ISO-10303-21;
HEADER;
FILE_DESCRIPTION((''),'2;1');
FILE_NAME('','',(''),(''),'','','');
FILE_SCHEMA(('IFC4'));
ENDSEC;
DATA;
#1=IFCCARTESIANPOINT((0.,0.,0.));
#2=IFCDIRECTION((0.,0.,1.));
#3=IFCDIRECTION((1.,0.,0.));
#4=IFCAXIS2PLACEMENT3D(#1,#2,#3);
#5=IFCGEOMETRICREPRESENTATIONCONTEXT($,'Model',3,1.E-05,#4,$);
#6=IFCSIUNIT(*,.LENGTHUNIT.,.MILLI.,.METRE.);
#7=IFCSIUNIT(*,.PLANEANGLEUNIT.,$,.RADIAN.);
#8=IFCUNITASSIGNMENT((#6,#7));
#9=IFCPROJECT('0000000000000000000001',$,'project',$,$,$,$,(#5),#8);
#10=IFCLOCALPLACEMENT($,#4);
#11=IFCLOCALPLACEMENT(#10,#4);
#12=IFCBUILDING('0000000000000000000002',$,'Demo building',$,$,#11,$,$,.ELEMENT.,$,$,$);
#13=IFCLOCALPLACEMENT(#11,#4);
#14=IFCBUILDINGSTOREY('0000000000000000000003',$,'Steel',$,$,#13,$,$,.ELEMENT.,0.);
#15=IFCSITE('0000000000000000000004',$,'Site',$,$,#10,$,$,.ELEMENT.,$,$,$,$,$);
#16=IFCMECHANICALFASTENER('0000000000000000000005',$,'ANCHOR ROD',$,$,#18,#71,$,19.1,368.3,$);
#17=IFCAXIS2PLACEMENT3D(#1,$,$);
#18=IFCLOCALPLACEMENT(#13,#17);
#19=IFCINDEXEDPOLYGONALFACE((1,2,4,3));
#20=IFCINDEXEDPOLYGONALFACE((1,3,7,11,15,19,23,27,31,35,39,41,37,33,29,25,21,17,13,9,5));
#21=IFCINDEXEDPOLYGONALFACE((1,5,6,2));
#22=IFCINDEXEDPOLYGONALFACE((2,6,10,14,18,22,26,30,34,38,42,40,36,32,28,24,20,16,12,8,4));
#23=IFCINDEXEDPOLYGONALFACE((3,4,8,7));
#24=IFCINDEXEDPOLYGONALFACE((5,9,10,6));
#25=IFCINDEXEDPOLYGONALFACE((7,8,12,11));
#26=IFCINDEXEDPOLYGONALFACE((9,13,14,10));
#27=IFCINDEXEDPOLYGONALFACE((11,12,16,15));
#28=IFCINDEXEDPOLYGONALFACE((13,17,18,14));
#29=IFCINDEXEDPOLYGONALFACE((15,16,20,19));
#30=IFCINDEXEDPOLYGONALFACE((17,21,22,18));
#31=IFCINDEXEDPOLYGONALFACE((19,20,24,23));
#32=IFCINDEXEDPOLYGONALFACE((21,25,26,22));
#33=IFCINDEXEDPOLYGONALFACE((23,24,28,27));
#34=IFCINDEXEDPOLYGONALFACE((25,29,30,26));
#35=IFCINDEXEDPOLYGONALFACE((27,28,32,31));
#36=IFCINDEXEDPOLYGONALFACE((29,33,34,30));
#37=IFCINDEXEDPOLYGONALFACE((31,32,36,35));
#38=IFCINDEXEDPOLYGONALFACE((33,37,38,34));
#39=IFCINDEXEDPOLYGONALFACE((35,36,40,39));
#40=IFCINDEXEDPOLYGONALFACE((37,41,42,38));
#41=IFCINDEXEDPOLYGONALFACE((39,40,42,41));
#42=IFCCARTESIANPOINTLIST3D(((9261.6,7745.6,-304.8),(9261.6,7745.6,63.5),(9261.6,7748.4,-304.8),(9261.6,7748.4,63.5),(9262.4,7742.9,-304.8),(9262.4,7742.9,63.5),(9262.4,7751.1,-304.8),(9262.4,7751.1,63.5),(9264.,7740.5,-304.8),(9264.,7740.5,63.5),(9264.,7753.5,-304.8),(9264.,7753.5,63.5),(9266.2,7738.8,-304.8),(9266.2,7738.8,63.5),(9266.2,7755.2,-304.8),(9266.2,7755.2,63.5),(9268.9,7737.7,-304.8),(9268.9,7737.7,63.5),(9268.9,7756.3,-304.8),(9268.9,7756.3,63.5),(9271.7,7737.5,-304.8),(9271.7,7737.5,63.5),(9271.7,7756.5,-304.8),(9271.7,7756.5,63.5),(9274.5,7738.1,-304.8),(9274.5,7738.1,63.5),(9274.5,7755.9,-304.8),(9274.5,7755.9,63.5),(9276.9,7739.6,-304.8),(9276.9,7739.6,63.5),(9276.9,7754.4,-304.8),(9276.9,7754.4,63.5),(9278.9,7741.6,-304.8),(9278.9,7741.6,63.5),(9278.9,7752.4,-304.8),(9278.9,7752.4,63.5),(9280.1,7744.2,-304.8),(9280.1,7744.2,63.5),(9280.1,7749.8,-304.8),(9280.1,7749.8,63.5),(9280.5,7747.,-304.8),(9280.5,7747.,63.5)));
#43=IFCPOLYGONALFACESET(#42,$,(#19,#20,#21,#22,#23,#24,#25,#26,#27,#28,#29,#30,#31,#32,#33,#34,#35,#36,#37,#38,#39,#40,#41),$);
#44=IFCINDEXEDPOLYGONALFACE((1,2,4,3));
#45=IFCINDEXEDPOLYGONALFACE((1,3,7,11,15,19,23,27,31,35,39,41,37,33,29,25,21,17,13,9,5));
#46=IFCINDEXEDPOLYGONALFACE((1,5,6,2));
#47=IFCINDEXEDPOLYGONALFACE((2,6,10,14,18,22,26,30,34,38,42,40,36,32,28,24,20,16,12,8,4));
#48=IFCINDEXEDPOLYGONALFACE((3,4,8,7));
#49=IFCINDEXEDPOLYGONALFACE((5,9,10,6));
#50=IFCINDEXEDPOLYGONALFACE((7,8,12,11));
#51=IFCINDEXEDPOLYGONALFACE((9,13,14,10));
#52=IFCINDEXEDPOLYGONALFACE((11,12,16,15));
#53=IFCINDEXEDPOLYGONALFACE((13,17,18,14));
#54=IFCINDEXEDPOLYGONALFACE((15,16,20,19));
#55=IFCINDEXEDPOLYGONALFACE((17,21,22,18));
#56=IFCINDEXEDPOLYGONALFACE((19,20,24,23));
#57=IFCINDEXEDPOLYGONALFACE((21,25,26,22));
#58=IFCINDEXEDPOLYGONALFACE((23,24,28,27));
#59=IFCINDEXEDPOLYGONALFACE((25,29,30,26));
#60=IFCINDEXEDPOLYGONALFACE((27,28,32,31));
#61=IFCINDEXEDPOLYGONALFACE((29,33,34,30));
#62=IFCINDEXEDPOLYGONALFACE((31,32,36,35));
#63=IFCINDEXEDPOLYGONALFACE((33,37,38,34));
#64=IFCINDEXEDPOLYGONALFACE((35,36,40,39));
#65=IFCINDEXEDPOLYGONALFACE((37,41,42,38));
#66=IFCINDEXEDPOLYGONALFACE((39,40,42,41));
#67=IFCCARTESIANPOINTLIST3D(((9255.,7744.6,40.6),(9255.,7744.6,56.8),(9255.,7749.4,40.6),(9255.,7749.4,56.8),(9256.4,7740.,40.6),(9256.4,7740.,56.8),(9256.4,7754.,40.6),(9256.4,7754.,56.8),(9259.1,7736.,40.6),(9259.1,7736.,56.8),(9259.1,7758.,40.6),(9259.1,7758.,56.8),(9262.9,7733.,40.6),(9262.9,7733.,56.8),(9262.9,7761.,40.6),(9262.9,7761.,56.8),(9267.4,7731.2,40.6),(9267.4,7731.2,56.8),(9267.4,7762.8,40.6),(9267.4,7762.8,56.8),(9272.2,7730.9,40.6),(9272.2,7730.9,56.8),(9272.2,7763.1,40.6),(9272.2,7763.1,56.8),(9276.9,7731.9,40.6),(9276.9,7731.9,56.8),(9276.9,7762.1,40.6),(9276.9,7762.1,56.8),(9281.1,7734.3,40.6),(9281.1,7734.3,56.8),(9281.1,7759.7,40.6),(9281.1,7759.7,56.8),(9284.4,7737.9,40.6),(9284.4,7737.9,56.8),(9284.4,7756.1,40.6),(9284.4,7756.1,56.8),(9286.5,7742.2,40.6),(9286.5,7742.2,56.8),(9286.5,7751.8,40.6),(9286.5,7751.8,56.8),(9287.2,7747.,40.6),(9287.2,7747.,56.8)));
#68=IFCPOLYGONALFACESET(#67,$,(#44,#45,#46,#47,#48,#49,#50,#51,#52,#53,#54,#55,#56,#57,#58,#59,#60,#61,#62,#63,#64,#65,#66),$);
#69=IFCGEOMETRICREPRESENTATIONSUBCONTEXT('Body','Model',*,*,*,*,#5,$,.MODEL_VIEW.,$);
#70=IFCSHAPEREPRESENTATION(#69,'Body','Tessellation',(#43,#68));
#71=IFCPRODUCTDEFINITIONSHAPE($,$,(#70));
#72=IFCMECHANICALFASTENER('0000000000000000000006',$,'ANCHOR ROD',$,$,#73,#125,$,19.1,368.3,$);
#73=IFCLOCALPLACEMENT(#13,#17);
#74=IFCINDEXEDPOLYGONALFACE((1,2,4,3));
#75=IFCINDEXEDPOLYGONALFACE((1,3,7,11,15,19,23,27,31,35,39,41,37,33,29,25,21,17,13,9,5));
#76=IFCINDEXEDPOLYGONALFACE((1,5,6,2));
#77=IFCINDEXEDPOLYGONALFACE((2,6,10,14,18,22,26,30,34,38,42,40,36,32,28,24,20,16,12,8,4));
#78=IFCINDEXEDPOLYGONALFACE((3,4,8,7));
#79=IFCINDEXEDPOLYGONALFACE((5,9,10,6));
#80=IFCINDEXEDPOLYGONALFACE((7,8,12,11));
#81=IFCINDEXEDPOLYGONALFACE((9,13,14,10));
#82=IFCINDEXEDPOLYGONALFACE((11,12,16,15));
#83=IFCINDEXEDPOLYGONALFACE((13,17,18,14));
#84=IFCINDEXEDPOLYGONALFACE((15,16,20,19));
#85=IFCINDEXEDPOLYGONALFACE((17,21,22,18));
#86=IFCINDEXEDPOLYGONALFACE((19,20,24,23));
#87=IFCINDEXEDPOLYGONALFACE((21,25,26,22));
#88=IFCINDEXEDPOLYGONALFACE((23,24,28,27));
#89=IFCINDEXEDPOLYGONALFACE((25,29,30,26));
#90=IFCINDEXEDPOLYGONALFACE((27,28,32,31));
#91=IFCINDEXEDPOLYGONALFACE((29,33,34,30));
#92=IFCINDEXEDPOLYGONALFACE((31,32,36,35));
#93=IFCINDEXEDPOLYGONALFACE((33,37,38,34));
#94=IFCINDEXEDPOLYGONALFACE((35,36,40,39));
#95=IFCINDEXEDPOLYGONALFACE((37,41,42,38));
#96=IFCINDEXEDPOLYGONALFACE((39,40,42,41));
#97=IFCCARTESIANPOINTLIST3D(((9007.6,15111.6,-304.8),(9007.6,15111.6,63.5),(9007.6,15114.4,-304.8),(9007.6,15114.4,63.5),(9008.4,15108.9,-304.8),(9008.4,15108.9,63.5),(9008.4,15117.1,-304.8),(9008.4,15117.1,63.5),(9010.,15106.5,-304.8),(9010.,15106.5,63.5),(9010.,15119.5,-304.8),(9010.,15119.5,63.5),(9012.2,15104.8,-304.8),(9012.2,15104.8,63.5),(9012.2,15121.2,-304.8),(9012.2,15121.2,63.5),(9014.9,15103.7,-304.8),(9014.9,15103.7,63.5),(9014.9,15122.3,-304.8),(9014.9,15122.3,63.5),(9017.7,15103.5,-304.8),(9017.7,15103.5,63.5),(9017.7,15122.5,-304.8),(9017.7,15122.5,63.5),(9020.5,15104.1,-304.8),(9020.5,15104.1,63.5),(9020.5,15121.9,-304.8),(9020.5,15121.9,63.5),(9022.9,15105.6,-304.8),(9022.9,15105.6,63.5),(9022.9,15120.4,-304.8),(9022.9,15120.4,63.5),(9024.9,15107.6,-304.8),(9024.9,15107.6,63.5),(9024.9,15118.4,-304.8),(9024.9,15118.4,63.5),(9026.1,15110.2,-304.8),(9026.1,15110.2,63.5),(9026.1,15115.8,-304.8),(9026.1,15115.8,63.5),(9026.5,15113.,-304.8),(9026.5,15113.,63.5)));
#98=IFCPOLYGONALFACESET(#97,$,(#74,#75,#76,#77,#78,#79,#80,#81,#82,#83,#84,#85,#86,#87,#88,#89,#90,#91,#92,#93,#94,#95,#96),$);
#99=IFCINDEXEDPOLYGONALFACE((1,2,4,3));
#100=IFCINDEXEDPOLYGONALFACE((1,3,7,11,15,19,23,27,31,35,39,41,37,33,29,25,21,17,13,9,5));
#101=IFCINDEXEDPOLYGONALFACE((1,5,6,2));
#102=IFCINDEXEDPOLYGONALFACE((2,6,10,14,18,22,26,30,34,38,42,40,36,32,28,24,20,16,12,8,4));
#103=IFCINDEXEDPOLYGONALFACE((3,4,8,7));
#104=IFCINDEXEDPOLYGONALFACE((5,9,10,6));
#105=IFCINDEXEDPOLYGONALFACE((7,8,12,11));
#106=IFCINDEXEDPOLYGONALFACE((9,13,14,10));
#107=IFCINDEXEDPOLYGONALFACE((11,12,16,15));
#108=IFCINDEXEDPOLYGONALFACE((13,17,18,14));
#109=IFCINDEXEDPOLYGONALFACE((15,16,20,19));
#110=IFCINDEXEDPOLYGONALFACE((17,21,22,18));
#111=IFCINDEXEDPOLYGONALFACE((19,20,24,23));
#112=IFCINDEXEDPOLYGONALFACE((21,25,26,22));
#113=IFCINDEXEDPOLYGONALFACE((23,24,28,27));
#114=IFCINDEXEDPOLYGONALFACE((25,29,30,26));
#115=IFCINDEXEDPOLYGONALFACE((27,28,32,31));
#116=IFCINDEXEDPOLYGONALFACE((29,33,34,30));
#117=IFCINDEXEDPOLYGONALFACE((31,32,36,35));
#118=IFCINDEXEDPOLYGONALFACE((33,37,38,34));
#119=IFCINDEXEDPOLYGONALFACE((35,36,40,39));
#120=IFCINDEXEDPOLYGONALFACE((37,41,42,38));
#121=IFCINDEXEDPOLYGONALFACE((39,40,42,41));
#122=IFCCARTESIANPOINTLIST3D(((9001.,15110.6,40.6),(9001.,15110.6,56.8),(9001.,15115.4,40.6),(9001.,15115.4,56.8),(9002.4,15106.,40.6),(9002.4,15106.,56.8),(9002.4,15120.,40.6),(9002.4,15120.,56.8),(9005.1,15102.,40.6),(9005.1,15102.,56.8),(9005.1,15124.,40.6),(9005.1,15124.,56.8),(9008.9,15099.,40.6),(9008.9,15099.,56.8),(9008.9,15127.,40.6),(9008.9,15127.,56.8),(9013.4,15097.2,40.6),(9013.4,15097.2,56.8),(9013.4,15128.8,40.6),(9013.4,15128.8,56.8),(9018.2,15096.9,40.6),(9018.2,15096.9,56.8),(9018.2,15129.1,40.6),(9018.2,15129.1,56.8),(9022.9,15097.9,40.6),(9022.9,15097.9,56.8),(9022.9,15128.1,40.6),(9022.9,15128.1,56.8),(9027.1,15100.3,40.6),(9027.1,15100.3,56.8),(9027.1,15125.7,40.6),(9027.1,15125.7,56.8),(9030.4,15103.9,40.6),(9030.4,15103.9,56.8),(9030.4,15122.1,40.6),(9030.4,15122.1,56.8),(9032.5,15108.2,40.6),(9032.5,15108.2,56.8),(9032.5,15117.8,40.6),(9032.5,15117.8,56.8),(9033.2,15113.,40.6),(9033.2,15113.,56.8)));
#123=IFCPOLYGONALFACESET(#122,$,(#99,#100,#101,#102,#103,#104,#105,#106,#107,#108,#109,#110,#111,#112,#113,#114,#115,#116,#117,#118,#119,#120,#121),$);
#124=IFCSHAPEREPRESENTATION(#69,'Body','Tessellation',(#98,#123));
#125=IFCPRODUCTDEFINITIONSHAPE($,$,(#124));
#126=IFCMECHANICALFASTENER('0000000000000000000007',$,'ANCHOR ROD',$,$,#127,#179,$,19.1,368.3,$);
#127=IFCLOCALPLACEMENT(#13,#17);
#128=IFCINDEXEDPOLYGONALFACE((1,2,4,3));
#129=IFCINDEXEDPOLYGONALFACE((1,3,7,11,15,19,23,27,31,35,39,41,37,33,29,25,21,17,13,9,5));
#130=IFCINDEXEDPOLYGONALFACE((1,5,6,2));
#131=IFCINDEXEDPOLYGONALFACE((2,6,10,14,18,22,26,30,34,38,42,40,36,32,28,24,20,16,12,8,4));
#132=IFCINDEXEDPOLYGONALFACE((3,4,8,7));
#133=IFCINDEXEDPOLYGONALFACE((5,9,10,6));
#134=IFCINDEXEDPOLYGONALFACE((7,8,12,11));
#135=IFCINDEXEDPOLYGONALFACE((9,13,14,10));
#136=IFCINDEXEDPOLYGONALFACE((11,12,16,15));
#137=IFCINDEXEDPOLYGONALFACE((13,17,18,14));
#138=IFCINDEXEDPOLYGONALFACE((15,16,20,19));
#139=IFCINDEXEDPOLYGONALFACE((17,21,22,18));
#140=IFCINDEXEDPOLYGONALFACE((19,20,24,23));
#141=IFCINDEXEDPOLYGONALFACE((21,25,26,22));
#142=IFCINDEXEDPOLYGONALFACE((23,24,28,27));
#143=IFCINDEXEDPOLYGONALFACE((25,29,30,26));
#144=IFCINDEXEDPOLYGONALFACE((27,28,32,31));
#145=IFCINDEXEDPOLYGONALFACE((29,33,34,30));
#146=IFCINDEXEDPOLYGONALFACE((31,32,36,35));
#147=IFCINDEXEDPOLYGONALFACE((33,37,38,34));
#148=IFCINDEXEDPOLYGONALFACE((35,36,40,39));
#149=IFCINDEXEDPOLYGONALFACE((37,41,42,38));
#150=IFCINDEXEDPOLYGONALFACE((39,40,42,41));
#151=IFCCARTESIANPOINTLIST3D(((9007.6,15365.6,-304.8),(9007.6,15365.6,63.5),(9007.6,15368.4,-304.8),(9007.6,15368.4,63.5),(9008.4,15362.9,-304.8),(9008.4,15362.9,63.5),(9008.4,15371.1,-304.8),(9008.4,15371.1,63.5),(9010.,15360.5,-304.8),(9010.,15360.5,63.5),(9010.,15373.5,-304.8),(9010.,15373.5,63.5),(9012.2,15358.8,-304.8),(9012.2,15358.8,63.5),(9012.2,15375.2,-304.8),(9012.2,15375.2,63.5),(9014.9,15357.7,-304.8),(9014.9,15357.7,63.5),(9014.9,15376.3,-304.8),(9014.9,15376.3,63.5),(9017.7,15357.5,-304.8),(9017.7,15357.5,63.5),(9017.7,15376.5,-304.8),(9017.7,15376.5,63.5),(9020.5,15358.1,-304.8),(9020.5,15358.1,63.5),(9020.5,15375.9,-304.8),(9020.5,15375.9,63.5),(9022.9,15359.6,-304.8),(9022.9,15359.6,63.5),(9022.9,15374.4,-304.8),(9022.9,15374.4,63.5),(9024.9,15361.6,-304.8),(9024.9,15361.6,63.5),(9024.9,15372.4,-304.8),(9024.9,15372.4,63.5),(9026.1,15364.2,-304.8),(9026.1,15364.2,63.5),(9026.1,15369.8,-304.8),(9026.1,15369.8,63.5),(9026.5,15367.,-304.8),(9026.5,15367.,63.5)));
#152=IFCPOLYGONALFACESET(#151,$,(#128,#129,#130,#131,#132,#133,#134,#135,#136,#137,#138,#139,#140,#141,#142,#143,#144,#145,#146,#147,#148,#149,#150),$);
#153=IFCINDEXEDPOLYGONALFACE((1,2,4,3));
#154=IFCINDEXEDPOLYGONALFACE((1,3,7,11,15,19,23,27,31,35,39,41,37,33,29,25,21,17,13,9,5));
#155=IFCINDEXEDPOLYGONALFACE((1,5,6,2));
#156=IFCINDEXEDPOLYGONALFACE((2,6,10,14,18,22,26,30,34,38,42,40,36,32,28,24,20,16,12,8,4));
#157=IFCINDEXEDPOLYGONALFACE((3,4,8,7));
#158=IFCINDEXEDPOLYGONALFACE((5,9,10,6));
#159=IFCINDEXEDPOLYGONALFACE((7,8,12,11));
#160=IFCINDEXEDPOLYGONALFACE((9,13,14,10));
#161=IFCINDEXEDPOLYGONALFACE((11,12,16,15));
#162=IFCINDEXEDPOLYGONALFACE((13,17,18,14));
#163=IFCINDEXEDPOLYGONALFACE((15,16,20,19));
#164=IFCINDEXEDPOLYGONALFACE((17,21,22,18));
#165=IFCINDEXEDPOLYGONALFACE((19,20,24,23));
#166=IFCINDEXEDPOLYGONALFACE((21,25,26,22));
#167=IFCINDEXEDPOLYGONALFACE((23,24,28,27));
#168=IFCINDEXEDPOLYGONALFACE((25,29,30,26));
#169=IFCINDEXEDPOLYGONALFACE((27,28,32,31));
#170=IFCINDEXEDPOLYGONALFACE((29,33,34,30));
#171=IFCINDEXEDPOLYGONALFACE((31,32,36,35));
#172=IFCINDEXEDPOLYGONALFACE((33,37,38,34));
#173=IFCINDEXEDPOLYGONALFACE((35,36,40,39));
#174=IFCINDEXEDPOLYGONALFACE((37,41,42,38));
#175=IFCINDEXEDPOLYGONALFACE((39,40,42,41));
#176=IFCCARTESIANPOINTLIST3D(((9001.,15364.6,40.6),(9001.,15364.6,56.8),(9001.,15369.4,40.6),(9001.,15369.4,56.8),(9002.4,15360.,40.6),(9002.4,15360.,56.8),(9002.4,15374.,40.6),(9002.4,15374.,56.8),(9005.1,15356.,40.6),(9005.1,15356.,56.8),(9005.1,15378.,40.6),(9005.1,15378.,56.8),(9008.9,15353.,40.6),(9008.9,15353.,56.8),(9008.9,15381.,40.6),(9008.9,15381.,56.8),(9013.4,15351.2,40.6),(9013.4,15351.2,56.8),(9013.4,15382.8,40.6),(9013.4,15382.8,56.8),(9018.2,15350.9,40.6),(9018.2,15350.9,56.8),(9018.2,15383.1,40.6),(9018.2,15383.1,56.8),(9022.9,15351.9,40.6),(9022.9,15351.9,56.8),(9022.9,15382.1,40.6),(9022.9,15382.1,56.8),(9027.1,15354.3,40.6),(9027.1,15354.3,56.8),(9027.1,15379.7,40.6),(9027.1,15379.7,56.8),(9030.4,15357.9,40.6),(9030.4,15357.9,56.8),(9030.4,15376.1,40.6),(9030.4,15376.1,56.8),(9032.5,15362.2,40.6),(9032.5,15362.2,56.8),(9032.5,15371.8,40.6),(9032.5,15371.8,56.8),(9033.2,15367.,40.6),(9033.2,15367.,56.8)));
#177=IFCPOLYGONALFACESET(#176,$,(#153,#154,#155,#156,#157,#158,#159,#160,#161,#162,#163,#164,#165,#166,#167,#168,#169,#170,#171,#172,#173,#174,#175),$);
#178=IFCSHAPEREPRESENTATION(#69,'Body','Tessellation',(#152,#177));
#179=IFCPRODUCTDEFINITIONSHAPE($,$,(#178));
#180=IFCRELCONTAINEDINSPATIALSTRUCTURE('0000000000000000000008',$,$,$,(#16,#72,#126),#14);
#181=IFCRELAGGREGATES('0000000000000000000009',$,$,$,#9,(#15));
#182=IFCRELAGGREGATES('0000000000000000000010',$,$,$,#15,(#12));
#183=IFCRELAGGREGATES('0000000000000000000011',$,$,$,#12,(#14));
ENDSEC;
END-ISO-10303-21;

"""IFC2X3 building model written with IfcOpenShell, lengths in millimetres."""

from ifc_helpers import new_model, si_unit, frame, origin, origin_with_axes, origin_2d, place, context, subcontext, project, spatial, circle, extrude, element, save


model = new_model("IFC2X3")

# Units and contexts
model_context = context("Model", 3, precision=1e-05, world=origin_with_axes())
body_context = subcontext(model_context, "Body", "Model", "MODEL_VIEW")
ifc_project = project(units=[si_unit("LENGTHUNIT", "METRE", prefix="MILLI"), si_unit("PLANEANGLEUNIT", "RADIAN")], contexts=[model_context])

# Site, building, storey
site_placement = place(None, origin_with_axes())
site = spatial("IfcSite", under=ifc_project, at=site_placement, Name="Site", CompositionType="ELEMENT")
building_placement = place(site_placement, origin_with_axes())
building = spatial("IfcBuilding", under=site, at=building_placement, Name="Demo building", CompositionType="ELEMENT")
placement = place(building_placement, origin_with_axes())
storey = spatial("IfcBuildingStorey", under=building, at=placement, Name="Steel", CompositionType="ELEMENT", Elevation=0.0)

# Mechanical fasteners
for number, where, z_axis, x_axis, name in (
    (1, (9271.0, 7747.0, -304.8), (0.0, 0.0, 1.0), (1.0, 0.0, 0.0), "ANCHOR ROD"),
    (2, (9017.0, 15113.0, -304.8), (0.0, 0.0, 1.0), (1.0, 0.0, 0.0), "ANCHOR ROD"),
    (3, (9017.0, 15367.0, -304.8), (0.0, 0.0, 1.0), (1.0, 0.0, 0.0), "ANCHOR ROD"),
):
    element("IfcMechanicalFastener", number, at=place(placement, frame(where, z_axis=z_axis, x_axis=x_axis)), inside=storey, Name=name, NominalDiameter=19.1, NominalLength=368.3, context=body_context, shape_type="SweptSolid", body=[
        extrude(circle(Radius=9.5, at=origin_2d()), origin(), (0.0, 0.0, 1.0), 368.3),
        extrude(circle(Radius=16.2, at=origin_2d()), frame((0.0, 0.0, 345.4)), (0.0, 0.0, 1.0), 16.2),
    ])

save(model, "model.ifc")
